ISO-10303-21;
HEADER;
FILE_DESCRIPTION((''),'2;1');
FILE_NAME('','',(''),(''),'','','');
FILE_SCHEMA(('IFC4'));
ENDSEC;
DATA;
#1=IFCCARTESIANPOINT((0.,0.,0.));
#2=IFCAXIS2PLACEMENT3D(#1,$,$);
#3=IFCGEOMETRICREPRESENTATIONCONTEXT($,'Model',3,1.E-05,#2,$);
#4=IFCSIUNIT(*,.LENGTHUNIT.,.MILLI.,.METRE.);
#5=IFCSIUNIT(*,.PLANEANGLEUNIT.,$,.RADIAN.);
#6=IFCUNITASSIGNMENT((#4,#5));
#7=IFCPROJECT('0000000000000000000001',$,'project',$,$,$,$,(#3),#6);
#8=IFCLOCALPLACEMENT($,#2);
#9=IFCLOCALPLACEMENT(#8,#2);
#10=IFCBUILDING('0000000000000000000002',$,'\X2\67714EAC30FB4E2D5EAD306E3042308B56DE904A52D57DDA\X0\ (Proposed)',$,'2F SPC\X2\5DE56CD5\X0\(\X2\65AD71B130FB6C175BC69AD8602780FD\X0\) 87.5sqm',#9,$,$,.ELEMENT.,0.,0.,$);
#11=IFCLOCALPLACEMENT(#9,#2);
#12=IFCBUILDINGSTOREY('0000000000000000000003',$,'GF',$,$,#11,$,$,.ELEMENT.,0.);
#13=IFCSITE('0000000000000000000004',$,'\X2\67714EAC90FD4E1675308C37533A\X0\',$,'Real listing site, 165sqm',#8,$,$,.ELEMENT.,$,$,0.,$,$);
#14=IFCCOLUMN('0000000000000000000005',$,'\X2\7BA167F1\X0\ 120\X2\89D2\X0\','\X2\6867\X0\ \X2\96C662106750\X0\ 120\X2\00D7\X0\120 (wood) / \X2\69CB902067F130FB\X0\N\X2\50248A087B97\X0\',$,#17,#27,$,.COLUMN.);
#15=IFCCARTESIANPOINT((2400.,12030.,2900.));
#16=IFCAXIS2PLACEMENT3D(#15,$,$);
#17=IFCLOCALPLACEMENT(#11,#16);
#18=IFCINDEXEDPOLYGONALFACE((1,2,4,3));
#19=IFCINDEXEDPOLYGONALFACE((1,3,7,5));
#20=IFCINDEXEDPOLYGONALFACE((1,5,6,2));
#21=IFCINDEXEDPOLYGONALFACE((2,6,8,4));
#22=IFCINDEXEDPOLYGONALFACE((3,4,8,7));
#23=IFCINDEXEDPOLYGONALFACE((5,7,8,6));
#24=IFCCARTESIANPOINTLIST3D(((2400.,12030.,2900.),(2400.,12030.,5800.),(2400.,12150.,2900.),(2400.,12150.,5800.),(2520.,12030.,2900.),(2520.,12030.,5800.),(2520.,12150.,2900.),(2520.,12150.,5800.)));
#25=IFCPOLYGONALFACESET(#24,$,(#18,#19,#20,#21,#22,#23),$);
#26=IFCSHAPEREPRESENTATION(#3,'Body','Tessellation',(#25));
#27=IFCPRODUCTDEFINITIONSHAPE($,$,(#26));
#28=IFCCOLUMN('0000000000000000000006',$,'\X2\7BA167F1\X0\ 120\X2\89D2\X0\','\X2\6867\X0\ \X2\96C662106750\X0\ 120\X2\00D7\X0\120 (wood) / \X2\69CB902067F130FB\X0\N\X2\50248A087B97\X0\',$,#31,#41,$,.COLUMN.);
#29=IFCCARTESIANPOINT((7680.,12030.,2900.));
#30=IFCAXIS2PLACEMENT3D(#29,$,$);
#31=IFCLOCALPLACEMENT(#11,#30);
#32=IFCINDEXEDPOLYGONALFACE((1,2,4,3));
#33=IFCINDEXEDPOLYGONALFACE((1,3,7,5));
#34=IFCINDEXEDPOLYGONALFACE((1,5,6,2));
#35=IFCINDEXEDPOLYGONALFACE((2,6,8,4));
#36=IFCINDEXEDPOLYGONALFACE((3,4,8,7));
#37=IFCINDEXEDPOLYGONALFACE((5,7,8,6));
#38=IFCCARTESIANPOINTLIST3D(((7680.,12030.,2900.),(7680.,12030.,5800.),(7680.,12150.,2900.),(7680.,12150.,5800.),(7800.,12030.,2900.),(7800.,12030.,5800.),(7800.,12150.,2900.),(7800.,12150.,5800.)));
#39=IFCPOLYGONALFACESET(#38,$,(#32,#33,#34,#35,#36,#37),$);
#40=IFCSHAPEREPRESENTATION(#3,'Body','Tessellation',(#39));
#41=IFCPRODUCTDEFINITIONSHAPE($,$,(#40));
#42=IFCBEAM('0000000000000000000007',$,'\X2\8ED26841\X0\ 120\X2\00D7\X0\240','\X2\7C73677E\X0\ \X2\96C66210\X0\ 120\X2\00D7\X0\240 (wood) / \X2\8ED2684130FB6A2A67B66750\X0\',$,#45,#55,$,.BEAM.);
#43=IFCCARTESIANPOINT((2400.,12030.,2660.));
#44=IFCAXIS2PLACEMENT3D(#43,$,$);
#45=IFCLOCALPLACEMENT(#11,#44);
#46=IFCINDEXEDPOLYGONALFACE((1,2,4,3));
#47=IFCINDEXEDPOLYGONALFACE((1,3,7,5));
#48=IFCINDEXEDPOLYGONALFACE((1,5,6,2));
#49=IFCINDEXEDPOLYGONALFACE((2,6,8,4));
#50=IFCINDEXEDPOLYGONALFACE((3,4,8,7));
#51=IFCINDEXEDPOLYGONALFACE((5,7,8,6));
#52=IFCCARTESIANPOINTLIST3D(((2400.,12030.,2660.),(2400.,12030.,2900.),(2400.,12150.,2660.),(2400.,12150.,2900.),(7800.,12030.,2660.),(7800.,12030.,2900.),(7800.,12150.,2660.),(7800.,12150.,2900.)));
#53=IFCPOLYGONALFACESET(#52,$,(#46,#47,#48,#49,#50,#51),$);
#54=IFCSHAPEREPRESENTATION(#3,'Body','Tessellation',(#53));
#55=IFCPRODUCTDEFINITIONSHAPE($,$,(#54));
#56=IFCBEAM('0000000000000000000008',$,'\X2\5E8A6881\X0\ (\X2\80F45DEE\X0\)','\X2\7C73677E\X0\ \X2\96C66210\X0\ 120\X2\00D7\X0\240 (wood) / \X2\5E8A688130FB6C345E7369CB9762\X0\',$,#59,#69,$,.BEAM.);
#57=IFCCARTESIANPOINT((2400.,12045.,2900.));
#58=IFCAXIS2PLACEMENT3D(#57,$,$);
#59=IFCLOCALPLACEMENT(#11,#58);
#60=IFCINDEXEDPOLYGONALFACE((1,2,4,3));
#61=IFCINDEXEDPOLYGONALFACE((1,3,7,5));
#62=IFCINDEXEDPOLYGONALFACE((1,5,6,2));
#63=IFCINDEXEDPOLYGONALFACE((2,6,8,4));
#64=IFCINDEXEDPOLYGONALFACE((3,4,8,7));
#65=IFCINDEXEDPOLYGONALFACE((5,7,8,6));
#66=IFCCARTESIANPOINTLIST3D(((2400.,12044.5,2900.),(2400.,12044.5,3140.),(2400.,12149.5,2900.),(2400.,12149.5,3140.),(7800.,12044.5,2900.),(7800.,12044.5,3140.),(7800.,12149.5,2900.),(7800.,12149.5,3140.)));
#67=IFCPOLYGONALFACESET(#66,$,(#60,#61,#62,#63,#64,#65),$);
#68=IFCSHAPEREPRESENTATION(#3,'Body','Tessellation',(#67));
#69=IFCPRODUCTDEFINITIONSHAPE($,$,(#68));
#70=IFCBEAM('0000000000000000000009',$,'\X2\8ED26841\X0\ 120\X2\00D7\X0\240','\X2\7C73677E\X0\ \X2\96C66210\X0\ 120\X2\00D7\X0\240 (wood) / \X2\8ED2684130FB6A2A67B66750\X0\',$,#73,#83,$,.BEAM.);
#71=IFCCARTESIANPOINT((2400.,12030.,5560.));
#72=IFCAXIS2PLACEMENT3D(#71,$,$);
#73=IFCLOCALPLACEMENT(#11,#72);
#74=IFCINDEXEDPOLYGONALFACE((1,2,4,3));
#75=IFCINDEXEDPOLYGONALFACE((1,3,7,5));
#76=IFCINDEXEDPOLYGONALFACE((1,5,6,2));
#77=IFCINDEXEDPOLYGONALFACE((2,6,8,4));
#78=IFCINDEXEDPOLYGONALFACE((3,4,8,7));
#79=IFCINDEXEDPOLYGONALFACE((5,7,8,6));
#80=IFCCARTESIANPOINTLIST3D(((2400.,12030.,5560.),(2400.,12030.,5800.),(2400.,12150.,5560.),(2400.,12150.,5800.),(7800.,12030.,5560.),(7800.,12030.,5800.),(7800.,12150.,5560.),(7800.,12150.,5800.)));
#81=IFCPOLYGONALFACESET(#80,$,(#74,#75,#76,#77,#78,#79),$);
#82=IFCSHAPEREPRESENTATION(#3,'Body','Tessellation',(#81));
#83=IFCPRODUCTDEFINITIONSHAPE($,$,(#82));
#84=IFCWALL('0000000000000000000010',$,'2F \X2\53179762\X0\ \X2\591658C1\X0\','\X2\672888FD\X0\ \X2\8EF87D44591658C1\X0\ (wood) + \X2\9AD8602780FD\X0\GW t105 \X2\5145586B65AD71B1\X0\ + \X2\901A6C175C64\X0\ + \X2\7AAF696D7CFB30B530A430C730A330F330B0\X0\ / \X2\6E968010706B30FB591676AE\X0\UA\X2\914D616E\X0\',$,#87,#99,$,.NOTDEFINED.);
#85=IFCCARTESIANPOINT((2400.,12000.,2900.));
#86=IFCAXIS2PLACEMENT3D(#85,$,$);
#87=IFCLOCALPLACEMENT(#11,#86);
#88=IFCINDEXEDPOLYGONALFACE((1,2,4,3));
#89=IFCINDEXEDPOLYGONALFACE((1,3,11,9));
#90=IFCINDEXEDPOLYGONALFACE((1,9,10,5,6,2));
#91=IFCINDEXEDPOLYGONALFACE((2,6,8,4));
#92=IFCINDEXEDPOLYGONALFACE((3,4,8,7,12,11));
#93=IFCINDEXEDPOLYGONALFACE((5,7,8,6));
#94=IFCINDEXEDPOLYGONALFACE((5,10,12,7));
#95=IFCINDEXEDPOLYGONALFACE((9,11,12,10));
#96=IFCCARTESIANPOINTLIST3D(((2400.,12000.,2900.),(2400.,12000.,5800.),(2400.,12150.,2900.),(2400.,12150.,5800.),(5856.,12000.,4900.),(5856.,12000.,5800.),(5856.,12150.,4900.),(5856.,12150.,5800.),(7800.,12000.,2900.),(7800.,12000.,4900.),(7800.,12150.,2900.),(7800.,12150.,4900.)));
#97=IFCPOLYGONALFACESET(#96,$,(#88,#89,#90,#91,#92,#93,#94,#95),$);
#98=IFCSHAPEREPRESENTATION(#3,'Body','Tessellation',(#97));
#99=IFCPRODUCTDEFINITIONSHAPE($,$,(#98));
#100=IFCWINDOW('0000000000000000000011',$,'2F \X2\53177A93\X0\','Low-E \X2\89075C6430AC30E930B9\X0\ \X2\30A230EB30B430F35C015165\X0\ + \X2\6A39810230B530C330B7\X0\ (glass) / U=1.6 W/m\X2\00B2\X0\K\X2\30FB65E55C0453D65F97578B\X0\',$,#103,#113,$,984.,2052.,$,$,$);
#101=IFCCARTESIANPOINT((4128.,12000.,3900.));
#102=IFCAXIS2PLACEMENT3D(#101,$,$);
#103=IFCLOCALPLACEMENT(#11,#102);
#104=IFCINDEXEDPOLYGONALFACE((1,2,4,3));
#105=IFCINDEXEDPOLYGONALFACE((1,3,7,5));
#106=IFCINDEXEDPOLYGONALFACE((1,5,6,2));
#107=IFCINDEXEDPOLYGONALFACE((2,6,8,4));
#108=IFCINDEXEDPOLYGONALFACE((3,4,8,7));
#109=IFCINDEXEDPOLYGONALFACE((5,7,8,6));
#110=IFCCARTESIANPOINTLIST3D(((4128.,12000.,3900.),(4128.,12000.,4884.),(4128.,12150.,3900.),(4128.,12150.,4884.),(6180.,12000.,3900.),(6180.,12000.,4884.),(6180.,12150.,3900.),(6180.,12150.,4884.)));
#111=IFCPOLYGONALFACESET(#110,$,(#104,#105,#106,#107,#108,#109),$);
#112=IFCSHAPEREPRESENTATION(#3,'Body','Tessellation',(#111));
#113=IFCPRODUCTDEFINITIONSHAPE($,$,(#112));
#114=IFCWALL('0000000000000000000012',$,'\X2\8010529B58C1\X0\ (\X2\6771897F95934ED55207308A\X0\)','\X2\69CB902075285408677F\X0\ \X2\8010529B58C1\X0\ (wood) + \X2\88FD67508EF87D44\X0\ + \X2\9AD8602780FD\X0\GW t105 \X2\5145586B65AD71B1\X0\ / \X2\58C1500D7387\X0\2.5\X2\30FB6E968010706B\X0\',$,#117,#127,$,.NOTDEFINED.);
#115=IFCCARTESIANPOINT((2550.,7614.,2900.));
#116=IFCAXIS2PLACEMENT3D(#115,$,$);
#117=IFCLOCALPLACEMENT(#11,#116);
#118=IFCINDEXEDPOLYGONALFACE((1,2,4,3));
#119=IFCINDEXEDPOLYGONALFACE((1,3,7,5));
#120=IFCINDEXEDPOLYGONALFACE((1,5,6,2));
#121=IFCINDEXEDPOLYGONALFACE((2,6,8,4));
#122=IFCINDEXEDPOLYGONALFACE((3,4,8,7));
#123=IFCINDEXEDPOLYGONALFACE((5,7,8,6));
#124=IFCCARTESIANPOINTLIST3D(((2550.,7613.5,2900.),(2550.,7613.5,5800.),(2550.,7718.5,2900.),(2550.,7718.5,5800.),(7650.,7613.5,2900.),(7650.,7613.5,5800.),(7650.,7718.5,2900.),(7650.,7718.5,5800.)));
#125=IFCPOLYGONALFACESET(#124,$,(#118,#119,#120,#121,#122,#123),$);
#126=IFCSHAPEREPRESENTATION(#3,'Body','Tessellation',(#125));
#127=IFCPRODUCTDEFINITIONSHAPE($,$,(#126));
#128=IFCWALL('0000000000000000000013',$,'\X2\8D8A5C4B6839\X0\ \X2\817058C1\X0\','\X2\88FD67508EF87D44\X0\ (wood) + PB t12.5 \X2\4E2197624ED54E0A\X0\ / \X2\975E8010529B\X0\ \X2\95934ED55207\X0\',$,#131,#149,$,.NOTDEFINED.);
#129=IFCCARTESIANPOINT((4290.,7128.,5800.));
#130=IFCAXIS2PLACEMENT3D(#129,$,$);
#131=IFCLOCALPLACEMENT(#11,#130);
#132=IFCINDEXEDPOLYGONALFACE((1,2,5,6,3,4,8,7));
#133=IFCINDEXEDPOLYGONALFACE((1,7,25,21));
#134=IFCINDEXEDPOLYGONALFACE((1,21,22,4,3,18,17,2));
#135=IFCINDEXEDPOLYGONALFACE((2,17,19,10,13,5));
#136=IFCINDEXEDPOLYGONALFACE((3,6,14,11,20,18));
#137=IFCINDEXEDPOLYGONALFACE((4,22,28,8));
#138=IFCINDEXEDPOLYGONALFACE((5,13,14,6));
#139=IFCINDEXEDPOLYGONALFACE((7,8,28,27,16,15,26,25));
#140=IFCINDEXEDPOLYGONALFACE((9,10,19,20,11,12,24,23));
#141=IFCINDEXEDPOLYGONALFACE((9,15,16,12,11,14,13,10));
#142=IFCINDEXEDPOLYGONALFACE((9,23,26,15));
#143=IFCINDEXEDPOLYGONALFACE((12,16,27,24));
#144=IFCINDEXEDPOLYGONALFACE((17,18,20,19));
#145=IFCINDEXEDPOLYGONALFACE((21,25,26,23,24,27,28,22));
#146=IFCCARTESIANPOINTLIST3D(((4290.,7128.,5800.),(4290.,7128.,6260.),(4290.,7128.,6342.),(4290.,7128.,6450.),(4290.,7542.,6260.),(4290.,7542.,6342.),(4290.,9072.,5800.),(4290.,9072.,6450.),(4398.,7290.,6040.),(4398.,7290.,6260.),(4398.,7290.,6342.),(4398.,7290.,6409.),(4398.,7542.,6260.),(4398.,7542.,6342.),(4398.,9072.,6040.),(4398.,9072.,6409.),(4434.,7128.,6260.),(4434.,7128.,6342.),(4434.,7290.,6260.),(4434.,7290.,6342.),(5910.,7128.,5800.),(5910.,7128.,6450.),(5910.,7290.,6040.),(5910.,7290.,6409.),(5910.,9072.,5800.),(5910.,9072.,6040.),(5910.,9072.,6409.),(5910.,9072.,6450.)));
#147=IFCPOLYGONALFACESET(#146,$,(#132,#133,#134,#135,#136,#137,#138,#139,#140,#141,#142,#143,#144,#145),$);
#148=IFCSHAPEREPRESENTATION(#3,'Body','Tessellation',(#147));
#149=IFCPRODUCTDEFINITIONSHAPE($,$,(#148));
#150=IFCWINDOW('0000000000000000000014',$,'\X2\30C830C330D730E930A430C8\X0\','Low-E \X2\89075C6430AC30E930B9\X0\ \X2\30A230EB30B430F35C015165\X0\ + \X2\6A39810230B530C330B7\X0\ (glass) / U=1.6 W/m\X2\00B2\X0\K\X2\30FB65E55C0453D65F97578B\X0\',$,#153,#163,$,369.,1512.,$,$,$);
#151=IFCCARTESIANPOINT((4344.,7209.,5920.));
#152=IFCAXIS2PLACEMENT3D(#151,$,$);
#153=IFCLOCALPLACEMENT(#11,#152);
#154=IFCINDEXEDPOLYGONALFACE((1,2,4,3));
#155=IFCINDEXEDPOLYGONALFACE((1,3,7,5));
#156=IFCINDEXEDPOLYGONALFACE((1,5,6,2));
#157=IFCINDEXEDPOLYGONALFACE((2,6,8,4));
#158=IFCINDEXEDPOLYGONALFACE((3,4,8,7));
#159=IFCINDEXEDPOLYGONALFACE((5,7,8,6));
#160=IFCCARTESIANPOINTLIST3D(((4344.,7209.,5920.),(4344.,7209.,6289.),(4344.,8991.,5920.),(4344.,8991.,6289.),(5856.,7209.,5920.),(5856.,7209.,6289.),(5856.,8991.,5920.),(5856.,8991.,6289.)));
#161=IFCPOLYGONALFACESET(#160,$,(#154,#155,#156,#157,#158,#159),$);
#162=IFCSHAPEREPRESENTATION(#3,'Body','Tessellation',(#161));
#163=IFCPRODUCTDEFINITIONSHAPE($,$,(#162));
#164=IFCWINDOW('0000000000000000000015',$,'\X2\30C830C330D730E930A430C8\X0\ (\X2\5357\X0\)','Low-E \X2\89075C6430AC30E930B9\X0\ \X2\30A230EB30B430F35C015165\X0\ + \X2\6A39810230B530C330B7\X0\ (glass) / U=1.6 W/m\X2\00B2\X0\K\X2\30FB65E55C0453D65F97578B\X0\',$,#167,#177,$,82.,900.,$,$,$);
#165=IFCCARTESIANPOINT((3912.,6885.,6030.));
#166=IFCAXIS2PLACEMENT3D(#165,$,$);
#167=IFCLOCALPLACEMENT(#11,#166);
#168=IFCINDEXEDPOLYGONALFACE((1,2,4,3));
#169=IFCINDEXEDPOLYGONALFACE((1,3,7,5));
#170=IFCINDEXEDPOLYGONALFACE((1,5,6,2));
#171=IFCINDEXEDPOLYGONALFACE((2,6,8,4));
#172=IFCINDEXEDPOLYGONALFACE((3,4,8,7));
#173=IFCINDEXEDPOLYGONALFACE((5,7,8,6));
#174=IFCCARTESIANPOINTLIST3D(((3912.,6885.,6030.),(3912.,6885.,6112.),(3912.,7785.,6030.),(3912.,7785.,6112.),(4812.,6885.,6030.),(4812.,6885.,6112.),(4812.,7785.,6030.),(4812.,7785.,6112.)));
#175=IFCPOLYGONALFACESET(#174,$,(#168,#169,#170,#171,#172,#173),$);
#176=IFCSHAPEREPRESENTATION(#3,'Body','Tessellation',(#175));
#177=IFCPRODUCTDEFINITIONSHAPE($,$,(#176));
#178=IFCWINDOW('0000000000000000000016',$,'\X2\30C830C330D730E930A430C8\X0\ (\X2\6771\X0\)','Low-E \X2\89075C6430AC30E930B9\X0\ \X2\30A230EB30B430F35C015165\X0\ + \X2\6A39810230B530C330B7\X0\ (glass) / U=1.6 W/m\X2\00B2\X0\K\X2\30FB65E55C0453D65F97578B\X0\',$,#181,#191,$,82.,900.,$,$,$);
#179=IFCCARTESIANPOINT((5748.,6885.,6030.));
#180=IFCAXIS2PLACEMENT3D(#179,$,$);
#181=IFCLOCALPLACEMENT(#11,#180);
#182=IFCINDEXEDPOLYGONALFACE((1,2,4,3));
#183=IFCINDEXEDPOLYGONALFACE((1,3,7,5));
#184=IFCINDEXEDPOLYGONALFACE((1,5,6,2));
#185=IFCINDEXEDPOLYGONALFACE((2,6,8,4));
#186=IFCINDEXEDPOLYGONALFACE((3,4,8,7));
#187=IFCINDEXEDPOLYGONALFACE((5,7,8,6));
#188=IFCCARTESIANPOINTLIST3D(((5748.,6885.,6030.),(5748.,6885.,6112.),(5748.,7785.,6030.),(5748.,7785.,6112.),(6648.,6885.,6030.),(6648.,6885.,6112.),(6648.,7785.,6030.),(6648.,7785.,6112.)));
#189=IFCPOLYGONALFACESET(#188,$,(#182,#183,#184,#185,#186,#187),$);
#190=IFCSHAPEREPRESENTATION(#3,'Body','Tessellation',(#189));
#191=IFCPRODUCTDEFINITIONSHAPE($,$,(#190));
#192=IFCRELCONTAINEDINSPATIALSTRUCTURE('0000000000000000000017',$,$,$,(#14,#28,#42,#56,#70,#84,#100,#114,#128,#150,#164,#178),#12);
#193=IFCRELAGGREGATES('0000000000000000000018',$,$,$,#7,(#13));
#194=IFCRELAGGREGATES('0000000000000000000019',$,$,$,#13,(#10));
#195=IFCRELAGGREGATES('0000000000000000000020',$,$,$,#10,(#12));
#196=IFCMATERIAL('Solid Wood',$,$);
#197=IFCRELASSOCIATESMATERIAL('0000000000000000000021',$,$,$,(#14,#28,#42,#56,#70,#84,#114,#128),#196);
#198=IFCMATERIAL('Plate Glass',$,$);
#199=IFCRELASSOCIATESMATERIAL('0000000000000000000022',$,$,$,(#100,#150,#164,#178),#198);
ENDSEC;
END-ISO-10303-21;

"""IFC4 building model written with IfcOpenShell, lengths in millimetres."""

from ifc_helpers import new_model, si_unit, frame, frame_2d, origin, place, context, project, spatial, rectangle, extrude, material, element, fill, save


model = new_model("IFC4")

# Units and contexts
model_context = context("Model", 3, precision=1e-05, world=origin())
ifc_project = project(units=[si_unit("LENGTHUNIT", "METRE", prefix="MILLI"), si_unit("PLANEANGLEUNIT", "RADIAN")], contexts=[model_context])

# Site, building, storey
site_placement = place(None, origin())
site = spatial("IfcSite", under=ifc_project, at=site_placement, Name="東京都世田谷区", ObjectType="Real listing site, 165sqm", CompositionType="ELEMENT", RefElevation=0.0)
building_placement = place(site_placement, origin())
building = spatial("IfcBuilding", under=site, at=building_placement, Name="東京・中庭のある回遊動線 (Proposed)", ObjectType="2F SPC工法(断熱・気密高性能) 87.5sqm", CompositionType="ELEMENT", ElevationOfRefHeight=0.0, ElevationOfTerrain=0.0)
storey_placement = place(building_placement, origin())
storey = spatial("IfcBuildingStorey", under=building, at=storey_placement, Name="GF", CompositionType="ELEMENT", Elevation=0.0)

# Columns
ifc_material_1 = material(Name="Solid Wood")
column_1_placement = place(storey_placement, frame((2400.0, 12030.0, 2900.0)))
element("IfcColumn", 1, at=column_1_placement, inside=storey, material=ifc_material_1, Name="管柱 120角", Description="桧 集成材 120×120 (wood) / 構造柱・N値計算", PredefinedType="COLUMN", context=model_context, shape_type="SweptSolid", body=[
    extrude(rectangle(XDim=120.0, YDim=120.0, at=frame_2d((60.0, 60.0))), frame((2400.0, 12030.0, 2900.0)), (0.0, 0.0, 1.0), 2900.0),
])
column_2_placement = place(storey_placement, frame((7680.0, 12030.0, 2900.0)))
element("IfcColumn", 2, at=column_2_placement, inside=storey, material=ifc_material_1, Name="管柱 120角", Description="桧 集成材 120×120 (wood) / 構造柱・N値計算", PredefinedType="COLUMN", context=model_context, shape_type="SweptSolid", body=[
    extrude(rectangle(XDim=120.0, YDim=120.0, at=frame_2d((60.0, 60.0))), frame((7680.0, 12030.0, 2900.0)), (0.0, 0.0, 1.0), 2900.0),
])

# Beams
beam_1_placement = place(storey_placement, frame((2400.0, 12030.0, 2660.0)))
element("IfcBeam", 3, at=beam_1_placement, inside=storey, material=ifc_material_1, Name="軒桁 120×240", Description="米松 集成 120×240 (wood) / 軒桁・横架材", PredefinedType="BEAM", context=model_context, shape_type="SweptSolid", body=[
    extrude(rectangle(XDim=5400.0, YDim=120.0, at=frame_2d((2700.0, 60.0))), frame((2400.0, 12030.0, 2660.0)), (0.0, 0.0, 1.0), 240.0),
])
beam_2_placement = place(storey_placement, frame((2400.0, 12045.0, 2900.0)))
element("IfcBeam", 4, at=beam_2_placement, inside=storey, material=ifc_material_1, Name="床梁 (胴差)", Description="米松 集成 120×240 (wood) / 床梁・水平構面", PredefinedType="BEAM", context=model_context, shape_type="SweptSolid", body=[
    extrude(rectangle(XDim=5400.0, YDim=105.0, at=frame_2d((2700.0, 52.0))), frame((2400.0, 12045.0, 2900.0)), (0.0, 0.0, 1.0), 240.0),
])
beam_3_placement = place(storey_placement, frame((2400.0, 12030.0, 5560.0)))
element("IfcBeam", 5, at=beam_3_placement, inside=storey, material=ifc_material_1, Name="軒桁 120×240", Description="米松 集成 120×240 (wood) / 軒桁・横架材", PredefinedType="BEAM", context=model_context, shape_type="SweptSolid", body=[
    extrude(rectangle(XDim=5400.0, YDim=120.0, at=frame_2d((2700.0, 60.0))), frame((2400.0, 12030.0, 5560.0)), (0.0, 0.0, 1.0), 240.0),
])

# Wall, opening, window
wall_1_placement = place(storey_placement, frame((2400.0, 12000.0, 2900.0)))
wall_1 = element("IfcWall", 6, at=wall_1_placement, inside=storey, material=ifc_material_1, Name="2F 北面 外壁", Description="木製 軸組外壁 (wood) + 高性能GW t105 充填断熱 + 通気層 + 窯業系サイディング / 準耐火・外皮UA配慮", PredefinedType="NOTDEFINED", context=model_context, shape_type="SweptSolid", body=[
    extrude(rectangle(XDim=5400.0, YDim=150.0, at=frame_2d((2700.0, 75.0))), frame((2400.0, 12000.0, 2900.0)), (0.0, 0.0, 1.0), 2900.0),
])
opening_1_placement = place(storey_placement, frame((4128.0, 12000.0, 3900.0)))
opening_1 = element("IfcOpeningElement", 7, at=opening_1_placement, cuts=wall_1, PredefinedType="NOTDEFINED", context=model_context, shape_type="SweptSolid", body=[
    extrude(rectangle(XDim=2052.0, YDim=150.0, at=frame_2d((1026.0, 75.0))), frame((4128.0, 12000.0, 3900.0)), (0.0, 0.0, 1.0), 984.0),
])
ifc_material_2 = material(Name="Plate Glass")
window_1_placement = place(storey_placement, frame((4128.0, 12000.0, 3900.0)))
window_1 = element("IfcWindow", 8, at=window_1_placement, inside=storey, material=ifc_material_2, Name="2F 北窓", Description="Low-E 複層ガラス アルゴン封入 + 樹脂サッシ (glass) / U=1.6 W/m²K・日射取得型", OverallHeight=984.0, OverallWidth=2052.0, context=model_context, shape_type="SweptSolid", body=[
    extrude(rectangle(XDim=2052.0, YDim=150.0, at=frame_2d((1026.0, 75.0))), frame((4128.0, 12000.0, 3900.0)), (0.0, 0.0, 1.0), 984.0),
])
fill(opening_1, window_1)

# Wall
wall_2_placement = place(storey_placement, frame((2550.0, 7614.0, 2900.0)))
element("IfcWall", 9, at=wall_2_placement, inside=storey, material=ifc_material_1, Name="耐力壁 (東西間仕切り)", Description="構造用合板 耐力壁 (wood) + 製材軸組 + 高性能GW t105 充填断熱 / 壁倍率2.5・準耐火", PredefinedType="NOTDEFINED", context=model_context, shape_type="SweptSolid", body=[
    extrude(rectangle(XDim=5100.0, YDim=105.0, at=frame_2d((2550.0, 52.0))), frame((2550.0, 7614.0, 2900.0)), (0.0, 0.0, 1.0), 2900.0),
])

# Wall, openings, windows
wall_3_placement = place(storey_placement, frame((4290.0, 7128.0, 5800.0)))
wall_3 = element("IfcWall", 10, at=wall_3_placement, inside=storey, material=ifc_material_1, Name="越屋根 腰壁", Description="製材軸組 (wood) + PB t12.5 両面仕上 / 非耐力 間仕切", PredefinedType="NOTDEFINED", context=model_context, shape_type="SweptSolid", body=[
    extrude(rectangle(XDim=1620.0, YDim=1944.0, at=frame_2d((810.0, 972.0))), frame((4290.0, 7128.0, 5800.0)), (0.0, 0.0, 1.0), 650.0),
])
opening_2_placement = place(storey_placement, frame((4344.0, 7209.0, 5920.0)))
opening_2 = element("IfcOpeningElement", 11, at=opening_2_placement, cuts=wall_3, PredefinedType="NOTDEFINED", context=model_context, shape_type="SweptSolid", body=[
    extrude(rectangle(XDim=1512.0, YDim=1782.0, at=frame_2d((756.0, 891.0))), frame((4344.0, 7209.0, 5920.0)), (0.0, 0.0, 1.0), 369.0),
])
opening_3_placement = place(storey_placement, frame((3912.0, 6885.0, 6030.0)))
opening_3 = element("IfcOpeningElement", 12, at=opening_3_placement, cuts=wall_3, PredefinedType="NOTDEFINED", context=model_context, shape_type="SweptSolid", body=[
    extrude(rectangle(XDim=900.0, YDim=900.0, at=frame_2d((450.0, 450.0))), frame((3912.0, 6885.0, 6030.0)), (0.0, 0.0, 1.0), 82.0),
])
opening_4_placement = place(storey_placement, frame((5748.0, 6885.0, 6030.0)))
opening_4 = element("IfcOpeningElement", 13, at=opening_4_placement, cuts=wall_3, PredefinedType="NOTDEFINED", context=model_context, shape_type="SweptSolid", body=[
    extrude(rectangle(XDim=900.0, YDim=900.0, at=frame_2d((450.0, 450.0))), frame((5748.0, 6885.0, 6030.0)), (0.0, 0.0, 1.0), 82.0),
])
window_2_placement = place(storey_placement, frame((4344.0, 7209.0, 5920.0)))
window_2 = element("IfcWindow", 14, at=window_2_placement, inside=storey, material=ifc_material_2, Name="トップライト", Description="Low-E 複層ガラス アルゴン封入 + 樹脂サッシ (glass) / U=1.6 W/m²K・日射取得型", OverallHeight=369.0, OverallWidth=1512.0, context=model_context, shape_type="SweptSolid", body=[
    extrude(rectangle(XDim=1512.0, YDim=1782.0, at=frame_2d((756.0, 891.0))), frame((4344.0, 7209.0, 5920.0)), (0.0, 0.0, 1.0), 369.0),
])
fill(opening_2, window_2)
window_3_placement = place(storey_placement, frame((3912.0, 6885.0, 6030.0)))
window_3 = element("IfcWindow", 15, at=window_3_placement, inside=storey, material=ifc_material_2, Name="トップライト (南)", Description="Low-E 複層ガラス アルゴン封入 + 樹脂サッシ (glass) / U=1.6 W/m²K・日射取得型", OverallHeight=82.0, OverallWidth=900.0, context=model_context, shape_type="SweptSolid", body=[
    extrude(rectangle(XDim=900.0, YDim=900.0, at=frame_2d((450.0, 450.0))), frame((3912.0, 6885.0, 6030.0)), (0.0, 0.0, 1.0), 82.0),
])
fill(opening_3, window_3)
window_4_placement = place(storey_placement, frame((5748.0, 6885.0, 6030.0)))
window_4 = element("IfcWindow", 16, at=window_4_placement, inside=storey, material=ifc_material_2, Name="トップライト (東)", Description="Low-E 複層ガラス アルゴン封入 + 樹脂サッシ (glass) / U=1.6 W/m²K・日射取得型", OverallHeight=82.0, OverallWidth=900.0, context=model_context, shape_type="SweptSolid", body=[
    extrude(rectangle(XDim=900.0, YDim=900.0, at=frame_2d((450.0, 450.0))), frame((5748.0, 6885.0, 6030.0)), (0.0, 0.0, 1.0), 82.0),
])
fill(opening_4, window_4)

save(model, "model.ifc")
